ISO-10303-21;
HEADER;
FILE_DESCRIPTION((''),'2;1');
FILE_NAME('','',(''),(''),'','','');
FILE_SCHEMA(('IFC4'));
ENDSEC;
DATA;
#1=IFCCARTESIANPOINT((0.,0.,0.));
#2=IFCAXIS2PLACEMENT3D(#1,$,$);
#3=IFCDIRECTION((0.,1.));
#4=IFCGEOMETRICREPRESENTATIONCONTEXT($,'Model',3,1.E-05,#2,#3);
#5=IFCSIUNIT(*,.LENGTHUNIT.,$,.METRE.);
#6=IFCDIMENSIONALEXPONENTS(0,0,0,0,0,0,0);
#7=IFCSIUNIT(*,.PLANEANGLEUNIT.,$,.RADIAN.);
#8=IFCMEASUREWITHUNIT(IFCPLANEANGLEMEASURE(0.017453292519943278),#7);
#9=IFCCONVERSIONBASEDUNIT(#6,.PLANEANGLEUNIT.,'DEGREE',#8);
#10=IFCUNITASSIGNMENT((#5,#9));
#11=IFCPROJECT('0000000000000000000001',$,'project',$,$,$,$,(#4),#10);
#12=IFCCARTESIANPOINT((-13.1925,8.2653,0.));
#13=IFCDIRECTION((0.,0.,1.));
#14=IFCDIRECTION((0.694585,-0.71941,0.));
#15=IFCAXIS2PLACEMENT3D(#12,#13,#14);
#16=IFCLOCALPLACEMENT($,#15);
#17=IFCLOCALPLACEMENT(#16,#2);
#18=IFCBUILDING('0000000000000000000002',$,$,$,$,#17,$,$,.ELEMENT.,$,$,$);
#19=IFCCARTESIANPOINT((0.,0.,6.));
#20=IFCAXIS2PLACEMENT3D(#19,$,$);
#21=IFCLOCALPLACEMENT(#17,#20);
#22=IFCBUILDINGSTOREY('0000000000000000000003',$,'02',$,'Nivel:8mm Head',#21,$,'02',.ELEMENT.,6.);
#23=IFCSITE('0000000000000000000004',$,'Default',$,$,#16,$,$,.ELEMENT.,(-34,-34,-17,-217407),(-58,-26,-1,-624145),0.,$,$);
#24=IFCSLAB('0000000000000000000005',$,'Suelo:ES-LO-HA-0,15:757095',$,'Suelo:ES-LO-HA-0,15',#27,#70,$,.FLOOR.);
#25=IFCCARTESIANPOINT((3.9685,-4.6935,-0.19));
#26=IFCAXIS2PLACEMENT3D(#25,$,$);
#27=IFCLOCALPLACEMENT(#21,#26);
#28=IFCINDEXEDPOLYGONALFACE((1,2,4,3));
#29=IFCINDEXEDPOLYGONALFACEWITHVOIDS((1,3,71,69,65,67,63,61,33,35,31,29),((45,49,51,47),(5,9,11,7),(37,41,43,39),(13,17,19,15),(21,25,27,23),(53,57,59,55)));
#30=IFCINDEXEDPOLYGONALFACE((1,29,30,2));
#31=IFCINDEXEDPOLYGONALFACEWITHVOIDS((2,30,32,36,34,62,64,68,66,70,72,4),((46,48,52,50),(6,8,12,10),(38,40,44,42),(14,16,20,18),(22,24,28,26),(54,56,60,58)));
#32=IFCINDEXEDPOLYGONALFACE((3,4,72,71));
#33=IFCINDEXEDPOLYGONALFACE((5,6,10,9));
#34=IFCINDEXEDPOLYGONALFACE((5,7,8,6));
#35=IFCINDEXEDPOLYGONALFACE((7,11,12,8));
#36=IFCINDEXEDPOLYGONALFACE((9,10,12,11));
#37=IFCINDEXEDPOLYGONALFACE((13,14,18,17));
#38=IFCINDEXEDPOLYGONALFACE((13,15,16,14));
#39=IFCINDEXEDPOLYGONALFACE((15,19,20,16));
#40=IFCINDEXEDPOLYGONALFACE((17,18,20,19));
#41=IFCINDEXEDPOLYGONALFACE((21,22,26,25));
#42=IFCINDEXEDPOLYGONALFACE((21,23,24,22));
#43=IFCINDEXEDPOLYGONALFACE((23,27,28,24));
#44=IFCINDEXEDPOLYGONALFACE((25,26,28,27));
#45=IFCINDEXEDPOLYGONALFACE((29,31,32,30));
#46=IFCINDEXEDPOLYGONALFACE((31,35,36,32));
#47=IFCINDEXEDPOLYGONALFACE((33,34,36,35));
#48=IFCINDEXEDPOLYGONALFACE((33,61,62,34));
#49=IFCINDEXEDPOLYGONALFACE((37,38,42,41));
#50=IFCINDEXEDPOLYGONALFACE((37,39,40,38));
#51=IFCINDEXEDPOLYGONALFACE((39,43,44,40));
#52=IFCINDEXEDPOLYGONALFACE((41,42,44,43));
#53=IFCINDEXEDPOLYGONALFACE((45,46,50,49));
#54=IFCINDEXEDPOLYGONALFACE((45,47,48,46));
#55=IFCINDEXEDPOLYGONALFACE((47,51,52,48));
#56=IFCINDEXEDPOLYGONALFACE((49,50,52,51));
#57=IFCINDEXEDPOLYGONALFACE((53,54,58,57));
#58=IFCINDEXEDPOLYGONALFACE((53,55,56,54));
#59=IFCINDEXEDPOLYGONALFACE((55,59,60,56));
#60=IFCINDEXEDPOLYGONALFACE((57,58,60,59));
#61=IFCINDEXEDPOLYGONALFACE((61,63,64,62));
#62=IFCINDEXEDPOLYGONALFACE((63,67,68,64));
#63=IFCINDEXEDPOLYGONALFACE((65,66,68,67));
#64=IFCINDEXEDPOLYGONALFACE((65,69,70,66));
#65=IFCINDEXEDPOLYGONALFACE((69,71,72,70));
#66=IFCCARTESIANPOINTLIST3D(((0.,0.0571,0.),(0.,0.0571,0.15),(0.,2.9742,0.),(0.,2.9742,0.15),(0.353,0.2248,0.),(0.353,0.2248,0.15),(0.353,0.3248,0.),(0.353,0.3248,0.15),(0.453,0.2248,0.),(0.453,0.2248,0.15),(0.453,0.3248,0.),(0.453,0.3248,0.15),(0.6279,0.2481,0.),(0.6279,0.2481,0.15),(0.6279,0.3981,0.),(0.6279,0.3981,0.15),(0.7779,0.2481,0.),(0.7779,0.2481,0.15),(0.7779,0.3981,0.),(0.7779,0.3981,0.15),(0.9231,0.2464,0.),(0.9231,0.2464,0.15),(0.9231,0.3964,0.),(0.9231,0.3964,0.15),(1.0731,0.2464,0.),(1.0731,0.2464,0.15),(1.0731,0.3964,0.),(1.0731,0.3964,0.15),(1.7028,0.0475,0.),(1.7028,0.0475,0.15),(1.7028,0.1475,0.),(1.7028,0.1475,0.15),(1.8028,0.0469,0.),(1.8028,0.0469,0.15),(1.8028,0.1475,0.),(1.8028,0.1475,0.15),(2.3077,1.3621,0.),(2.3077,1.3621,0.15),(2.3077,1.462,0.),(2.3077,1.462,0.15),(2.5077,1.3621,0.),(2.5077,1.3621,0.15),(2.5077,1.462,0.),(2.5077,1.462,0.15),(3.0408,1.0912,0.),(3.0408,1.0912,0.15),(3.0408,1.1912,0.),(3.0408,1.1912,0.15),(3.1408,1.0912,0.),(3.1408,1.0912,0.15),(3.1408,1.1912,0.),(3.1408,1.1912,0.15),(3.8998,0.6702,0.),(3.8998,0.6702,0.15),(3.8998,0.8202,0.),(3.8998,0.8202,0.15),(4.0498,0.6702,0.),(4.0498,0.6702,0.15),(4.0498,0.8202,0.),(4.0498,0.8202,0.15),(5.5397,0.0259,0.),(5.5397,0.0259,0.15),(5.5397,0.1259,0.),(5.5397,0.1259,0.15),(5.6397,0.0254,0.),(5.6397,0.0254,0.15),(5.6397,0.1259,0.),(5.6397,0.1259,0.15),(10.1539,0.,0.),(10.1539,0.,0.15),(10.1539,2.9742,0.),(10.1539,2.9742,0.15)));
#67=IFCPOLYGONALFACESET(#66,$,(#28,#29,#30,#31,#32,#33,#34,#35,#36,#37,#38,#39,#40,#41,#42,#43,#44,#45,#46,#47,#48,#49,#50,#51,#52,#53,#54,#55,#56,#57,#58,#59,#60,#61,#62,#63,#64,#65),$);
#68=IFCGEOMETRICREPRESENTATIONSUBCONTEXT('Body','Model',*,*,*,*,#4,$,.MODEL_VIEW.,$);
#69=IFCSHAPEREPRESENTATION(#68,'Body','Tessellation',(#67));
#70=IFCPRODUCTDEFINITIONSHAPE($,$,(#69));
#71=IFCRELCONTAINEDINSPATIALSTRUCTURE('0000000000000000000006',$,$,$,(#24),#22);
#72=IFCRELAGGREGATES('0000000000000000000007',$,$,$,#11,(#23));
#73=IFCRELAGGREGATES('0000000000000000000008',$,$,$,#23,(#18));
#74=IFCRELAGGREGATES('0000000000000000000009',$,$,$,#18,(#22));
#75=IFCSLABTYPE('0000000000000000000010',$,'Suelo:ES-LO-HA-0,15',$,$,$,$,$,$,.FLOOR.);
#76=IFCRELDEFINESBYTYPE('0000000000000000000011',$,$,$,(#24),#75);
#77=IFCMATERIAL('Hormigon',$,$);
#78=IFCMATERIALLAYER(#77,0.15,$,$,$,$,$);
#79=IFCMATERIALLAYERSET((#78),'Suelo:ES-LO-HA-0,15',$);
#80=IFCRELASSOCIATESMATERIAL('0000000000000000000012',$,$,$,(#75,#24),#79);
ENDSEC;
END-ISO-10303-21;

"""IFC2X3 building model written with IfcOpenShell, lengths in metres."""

from ifc_helpers import new_model, entity, si_unit, converted_unit, direction, frame, frame_2d, origin, origin_2d_with_axis, place, context, subcontext, project, spatial, polyline, rectangle, outline, extrude, material, layer, layer_set, layer_usage, type_object, element, save


model = new_model("IFC2X3")

# Units and contexts
model_context = context("Model", 3, precision=1e-05, world=origin(), true_north=direction((0.0, 1.0)))
body_context = subcontext(model_context, "Body", "Model", "MODEL_VIEW")
ifc_project = project(units=[si_unit("LENGTHUNIT", "METRE"), converted_unit("PLANEANGLEUNIT", "DEGREE", entity("IfcPlaneAngleMeasure", 0.017453292519943278), si_unit("PLANEANGLEUNIT", "RADIAN"), dimensions=[0, 0, 0, 0, 0, 0, 0])], contexts=[model_context])

# Site, building, storey
site_placement = place(None, frame((-13.1925, 8.2653, 0.0), z_axis=(0.0, 0.0, 1.0), x_axis=(0.694585, -0.71941, 0.0)))
site = spatial("IfcSite", under=ifc_project, at=site_placement, Name="Default", CompositionType="ELEMENT", RefLatitude=(-34, -34, -17, -217407), RefLongitude=(-58, -26, -1, -624145), RefElevation=0.0)
building_placement = place(site_placement, origin())
building = spatial("IfcBuilding", under=site, at=building_placement, CompositionType="ELEMENT")
storey_placement = place(building_placement, frame((0.0, 0.0, 6.0)))
storey = spatial("IfcBuildingStorey", under=building, at=storey_placement, Name="02", ObjectType="Nivel:8mm Head", LongName="02", CompositionType="ELEMENT", Elevation=6.0)

# Shared definitions
ifc_material_1 = material(Name="Hormigon")

# Slab, openings
ifc_layer = layer(ifc_material_1, 0.15)
ifc_layer_set = layer_set([ifc_layer], Name="Suelo:ES-LO-HA-0,15")
ifc_layer_usage = layer_usage(ifc_layer_set, "AXIS3", "POSITIVE", 0.0)
slab_type = type_object("IfcSlabType", Name="Suelo:ES-LO-HA-0,15", PredefinedType="FLOOR", material=ifc_layer_set)
slab_placement = place(storey_placement, frame((3.9685, -4.6935, -0.19)))
slab = element("IfcSlab", 1, at=slab_placement, inside=storey, type_object=slab_type, material=ifc_layer_usage, Name="Suelo:ES-LO-HA-0,15:757095", ObjectType="Suelo:ES-LO-HA-0,15", PredefinedType="FLOOR", context=body_context, shape_type="SweptSolid", body=[
    extrude(outline(polyline([(-5.077, 1.4871), (-5.077, -1.4871), (-0.5627, -1.4617), (-0.5627, -1.3612), (-0.4627, -1.3612), (-0.4627, -1.4612), (3.2742, -1.4402), (3.2742, -1.3396), (3.3742, -1.3396), (3.3742, -1.4396), (5.077, -1.43), (5.077, 1.4871), (-5.077, 1.4871)])), frame((5.077, 1.4871, 0.15), z_axis=(0.0, 0.0, -1.0), x_axis=(-1.0, 0.0, 0.0)), (0.0, 0.0, 1.0), 0.15),
])
opening_1_placement = place(slab_placement, origin())
element("IfcOpeningElement", 2, at=opening_1_placement, cuts=slab, ObjectType="Opening", context=body_context, shape_type="SweptSolid", body=[
    extrude(rectangle(XDim=0.1, YDim=0.2, at=origin_2d_with_axis()), frame((2.4077, 1.412, 0.15), z_axis=(0.0, 0.0, -1.0), x_axis=(0.0, -1.0, 0.0)), (0.0, 0.0, 1.0), 0.15),
])
opening_2_placement = place(slab_placement, origin())
element("IfcOpeningElement", 3, at=opening_2_placement, cuts=slab, ObjectType="Opening", context=body_context, shape_type="SweptSolid", body=[
    extrude(rectangle(XDim=0.1, YDim=0.1, at=frame_2d((0.0, 0.0), x_axis=(1.0, 0.0))), frame((3.0908, 1.1412, 0.15), z_axis=(0.0, 0.0, -1.0), x_axis=(0.0, -1.0, 0.0)), (0.0, 0.0, 1.0), 0.15),
])
opening_3_placement = place(slab_placement, origin())
element("IfcOpeningElement", 4, at=opening_3_placement, cuts=slab, ObjectType="Opening", context=body_context, shape_type="SweptSolid", body=[
    extrude(rectangle(XDim=0.15, YDim=0.15, at=frame_2d((0.0, 0.0), x_axis=(1.0, 0.0))), frame((3.9748, 0.7452, 0.15), z_axis=(0.0, 0.0, -1.0), x_axis=(0.0, -1.0, 0.0)), (0.0, 0.0, 1.0), 0.15),
])
opening_4_placement = place(slab_placement, origin())
element("IfcOpeningElement", 5, at=opening_4_placement, cuts=slab, ObjectType="Opening", context=body_context, shape_type="SweptSolid", body=[
    extrude(rectangle(XDim=0.15, YDim=0.15, at=frame_2d((0.0, 0.0), x_axis=(1.0, 0.0))), frame((0.9981, 0.3214, 0.15), z_axis=(0.0, 0.0, -1.0), x_axis=(0.0, -1.0, 0.0)), (0.0, 0.0, 1.0), 0.15),
])
opening_5_placement = place(slab_placement, origin())
element("IfcOpeningElement", 6, at=opening_5_placement, cuts=slab, ObjectType="Opening", context=body_context, shape_type="SweptSolid", body=[
    extrude(rectangle(XDim=0.15, YDim=0.15, at=frame_2d((0.0, 0.0), x_axis=(1.0, 0.0))), frame((0.7029, 0.3231, 0.15), z_axis=(0.0, 0.0, 1.0), x_axis=(0.0, -1.0, 0.0)), (0.0, 0.0, -1.0), 0.15),
])
opening_6_placement = place(slab_placement, origin())
element("IfcOpeningElement", 7, at=opening_6_placement, cuts=slab, ObjectType="Opening", context=body_context, shape_type="SweptSolid", body=[
    extrude(rectangle(XDim=0.1, YDim=0.1, at=frame_2d((0.0, 0.0), x_axis=(1.0, 0.0))), frame((0.403, 0.2748, 0.15), z_axis=(0.0, 0.0, -1.0), x_axis=(0.0, -1.0, 0.0)), (0.0, 0.0, 1.0), 0.15),
])

save(model, "model.ifc")
